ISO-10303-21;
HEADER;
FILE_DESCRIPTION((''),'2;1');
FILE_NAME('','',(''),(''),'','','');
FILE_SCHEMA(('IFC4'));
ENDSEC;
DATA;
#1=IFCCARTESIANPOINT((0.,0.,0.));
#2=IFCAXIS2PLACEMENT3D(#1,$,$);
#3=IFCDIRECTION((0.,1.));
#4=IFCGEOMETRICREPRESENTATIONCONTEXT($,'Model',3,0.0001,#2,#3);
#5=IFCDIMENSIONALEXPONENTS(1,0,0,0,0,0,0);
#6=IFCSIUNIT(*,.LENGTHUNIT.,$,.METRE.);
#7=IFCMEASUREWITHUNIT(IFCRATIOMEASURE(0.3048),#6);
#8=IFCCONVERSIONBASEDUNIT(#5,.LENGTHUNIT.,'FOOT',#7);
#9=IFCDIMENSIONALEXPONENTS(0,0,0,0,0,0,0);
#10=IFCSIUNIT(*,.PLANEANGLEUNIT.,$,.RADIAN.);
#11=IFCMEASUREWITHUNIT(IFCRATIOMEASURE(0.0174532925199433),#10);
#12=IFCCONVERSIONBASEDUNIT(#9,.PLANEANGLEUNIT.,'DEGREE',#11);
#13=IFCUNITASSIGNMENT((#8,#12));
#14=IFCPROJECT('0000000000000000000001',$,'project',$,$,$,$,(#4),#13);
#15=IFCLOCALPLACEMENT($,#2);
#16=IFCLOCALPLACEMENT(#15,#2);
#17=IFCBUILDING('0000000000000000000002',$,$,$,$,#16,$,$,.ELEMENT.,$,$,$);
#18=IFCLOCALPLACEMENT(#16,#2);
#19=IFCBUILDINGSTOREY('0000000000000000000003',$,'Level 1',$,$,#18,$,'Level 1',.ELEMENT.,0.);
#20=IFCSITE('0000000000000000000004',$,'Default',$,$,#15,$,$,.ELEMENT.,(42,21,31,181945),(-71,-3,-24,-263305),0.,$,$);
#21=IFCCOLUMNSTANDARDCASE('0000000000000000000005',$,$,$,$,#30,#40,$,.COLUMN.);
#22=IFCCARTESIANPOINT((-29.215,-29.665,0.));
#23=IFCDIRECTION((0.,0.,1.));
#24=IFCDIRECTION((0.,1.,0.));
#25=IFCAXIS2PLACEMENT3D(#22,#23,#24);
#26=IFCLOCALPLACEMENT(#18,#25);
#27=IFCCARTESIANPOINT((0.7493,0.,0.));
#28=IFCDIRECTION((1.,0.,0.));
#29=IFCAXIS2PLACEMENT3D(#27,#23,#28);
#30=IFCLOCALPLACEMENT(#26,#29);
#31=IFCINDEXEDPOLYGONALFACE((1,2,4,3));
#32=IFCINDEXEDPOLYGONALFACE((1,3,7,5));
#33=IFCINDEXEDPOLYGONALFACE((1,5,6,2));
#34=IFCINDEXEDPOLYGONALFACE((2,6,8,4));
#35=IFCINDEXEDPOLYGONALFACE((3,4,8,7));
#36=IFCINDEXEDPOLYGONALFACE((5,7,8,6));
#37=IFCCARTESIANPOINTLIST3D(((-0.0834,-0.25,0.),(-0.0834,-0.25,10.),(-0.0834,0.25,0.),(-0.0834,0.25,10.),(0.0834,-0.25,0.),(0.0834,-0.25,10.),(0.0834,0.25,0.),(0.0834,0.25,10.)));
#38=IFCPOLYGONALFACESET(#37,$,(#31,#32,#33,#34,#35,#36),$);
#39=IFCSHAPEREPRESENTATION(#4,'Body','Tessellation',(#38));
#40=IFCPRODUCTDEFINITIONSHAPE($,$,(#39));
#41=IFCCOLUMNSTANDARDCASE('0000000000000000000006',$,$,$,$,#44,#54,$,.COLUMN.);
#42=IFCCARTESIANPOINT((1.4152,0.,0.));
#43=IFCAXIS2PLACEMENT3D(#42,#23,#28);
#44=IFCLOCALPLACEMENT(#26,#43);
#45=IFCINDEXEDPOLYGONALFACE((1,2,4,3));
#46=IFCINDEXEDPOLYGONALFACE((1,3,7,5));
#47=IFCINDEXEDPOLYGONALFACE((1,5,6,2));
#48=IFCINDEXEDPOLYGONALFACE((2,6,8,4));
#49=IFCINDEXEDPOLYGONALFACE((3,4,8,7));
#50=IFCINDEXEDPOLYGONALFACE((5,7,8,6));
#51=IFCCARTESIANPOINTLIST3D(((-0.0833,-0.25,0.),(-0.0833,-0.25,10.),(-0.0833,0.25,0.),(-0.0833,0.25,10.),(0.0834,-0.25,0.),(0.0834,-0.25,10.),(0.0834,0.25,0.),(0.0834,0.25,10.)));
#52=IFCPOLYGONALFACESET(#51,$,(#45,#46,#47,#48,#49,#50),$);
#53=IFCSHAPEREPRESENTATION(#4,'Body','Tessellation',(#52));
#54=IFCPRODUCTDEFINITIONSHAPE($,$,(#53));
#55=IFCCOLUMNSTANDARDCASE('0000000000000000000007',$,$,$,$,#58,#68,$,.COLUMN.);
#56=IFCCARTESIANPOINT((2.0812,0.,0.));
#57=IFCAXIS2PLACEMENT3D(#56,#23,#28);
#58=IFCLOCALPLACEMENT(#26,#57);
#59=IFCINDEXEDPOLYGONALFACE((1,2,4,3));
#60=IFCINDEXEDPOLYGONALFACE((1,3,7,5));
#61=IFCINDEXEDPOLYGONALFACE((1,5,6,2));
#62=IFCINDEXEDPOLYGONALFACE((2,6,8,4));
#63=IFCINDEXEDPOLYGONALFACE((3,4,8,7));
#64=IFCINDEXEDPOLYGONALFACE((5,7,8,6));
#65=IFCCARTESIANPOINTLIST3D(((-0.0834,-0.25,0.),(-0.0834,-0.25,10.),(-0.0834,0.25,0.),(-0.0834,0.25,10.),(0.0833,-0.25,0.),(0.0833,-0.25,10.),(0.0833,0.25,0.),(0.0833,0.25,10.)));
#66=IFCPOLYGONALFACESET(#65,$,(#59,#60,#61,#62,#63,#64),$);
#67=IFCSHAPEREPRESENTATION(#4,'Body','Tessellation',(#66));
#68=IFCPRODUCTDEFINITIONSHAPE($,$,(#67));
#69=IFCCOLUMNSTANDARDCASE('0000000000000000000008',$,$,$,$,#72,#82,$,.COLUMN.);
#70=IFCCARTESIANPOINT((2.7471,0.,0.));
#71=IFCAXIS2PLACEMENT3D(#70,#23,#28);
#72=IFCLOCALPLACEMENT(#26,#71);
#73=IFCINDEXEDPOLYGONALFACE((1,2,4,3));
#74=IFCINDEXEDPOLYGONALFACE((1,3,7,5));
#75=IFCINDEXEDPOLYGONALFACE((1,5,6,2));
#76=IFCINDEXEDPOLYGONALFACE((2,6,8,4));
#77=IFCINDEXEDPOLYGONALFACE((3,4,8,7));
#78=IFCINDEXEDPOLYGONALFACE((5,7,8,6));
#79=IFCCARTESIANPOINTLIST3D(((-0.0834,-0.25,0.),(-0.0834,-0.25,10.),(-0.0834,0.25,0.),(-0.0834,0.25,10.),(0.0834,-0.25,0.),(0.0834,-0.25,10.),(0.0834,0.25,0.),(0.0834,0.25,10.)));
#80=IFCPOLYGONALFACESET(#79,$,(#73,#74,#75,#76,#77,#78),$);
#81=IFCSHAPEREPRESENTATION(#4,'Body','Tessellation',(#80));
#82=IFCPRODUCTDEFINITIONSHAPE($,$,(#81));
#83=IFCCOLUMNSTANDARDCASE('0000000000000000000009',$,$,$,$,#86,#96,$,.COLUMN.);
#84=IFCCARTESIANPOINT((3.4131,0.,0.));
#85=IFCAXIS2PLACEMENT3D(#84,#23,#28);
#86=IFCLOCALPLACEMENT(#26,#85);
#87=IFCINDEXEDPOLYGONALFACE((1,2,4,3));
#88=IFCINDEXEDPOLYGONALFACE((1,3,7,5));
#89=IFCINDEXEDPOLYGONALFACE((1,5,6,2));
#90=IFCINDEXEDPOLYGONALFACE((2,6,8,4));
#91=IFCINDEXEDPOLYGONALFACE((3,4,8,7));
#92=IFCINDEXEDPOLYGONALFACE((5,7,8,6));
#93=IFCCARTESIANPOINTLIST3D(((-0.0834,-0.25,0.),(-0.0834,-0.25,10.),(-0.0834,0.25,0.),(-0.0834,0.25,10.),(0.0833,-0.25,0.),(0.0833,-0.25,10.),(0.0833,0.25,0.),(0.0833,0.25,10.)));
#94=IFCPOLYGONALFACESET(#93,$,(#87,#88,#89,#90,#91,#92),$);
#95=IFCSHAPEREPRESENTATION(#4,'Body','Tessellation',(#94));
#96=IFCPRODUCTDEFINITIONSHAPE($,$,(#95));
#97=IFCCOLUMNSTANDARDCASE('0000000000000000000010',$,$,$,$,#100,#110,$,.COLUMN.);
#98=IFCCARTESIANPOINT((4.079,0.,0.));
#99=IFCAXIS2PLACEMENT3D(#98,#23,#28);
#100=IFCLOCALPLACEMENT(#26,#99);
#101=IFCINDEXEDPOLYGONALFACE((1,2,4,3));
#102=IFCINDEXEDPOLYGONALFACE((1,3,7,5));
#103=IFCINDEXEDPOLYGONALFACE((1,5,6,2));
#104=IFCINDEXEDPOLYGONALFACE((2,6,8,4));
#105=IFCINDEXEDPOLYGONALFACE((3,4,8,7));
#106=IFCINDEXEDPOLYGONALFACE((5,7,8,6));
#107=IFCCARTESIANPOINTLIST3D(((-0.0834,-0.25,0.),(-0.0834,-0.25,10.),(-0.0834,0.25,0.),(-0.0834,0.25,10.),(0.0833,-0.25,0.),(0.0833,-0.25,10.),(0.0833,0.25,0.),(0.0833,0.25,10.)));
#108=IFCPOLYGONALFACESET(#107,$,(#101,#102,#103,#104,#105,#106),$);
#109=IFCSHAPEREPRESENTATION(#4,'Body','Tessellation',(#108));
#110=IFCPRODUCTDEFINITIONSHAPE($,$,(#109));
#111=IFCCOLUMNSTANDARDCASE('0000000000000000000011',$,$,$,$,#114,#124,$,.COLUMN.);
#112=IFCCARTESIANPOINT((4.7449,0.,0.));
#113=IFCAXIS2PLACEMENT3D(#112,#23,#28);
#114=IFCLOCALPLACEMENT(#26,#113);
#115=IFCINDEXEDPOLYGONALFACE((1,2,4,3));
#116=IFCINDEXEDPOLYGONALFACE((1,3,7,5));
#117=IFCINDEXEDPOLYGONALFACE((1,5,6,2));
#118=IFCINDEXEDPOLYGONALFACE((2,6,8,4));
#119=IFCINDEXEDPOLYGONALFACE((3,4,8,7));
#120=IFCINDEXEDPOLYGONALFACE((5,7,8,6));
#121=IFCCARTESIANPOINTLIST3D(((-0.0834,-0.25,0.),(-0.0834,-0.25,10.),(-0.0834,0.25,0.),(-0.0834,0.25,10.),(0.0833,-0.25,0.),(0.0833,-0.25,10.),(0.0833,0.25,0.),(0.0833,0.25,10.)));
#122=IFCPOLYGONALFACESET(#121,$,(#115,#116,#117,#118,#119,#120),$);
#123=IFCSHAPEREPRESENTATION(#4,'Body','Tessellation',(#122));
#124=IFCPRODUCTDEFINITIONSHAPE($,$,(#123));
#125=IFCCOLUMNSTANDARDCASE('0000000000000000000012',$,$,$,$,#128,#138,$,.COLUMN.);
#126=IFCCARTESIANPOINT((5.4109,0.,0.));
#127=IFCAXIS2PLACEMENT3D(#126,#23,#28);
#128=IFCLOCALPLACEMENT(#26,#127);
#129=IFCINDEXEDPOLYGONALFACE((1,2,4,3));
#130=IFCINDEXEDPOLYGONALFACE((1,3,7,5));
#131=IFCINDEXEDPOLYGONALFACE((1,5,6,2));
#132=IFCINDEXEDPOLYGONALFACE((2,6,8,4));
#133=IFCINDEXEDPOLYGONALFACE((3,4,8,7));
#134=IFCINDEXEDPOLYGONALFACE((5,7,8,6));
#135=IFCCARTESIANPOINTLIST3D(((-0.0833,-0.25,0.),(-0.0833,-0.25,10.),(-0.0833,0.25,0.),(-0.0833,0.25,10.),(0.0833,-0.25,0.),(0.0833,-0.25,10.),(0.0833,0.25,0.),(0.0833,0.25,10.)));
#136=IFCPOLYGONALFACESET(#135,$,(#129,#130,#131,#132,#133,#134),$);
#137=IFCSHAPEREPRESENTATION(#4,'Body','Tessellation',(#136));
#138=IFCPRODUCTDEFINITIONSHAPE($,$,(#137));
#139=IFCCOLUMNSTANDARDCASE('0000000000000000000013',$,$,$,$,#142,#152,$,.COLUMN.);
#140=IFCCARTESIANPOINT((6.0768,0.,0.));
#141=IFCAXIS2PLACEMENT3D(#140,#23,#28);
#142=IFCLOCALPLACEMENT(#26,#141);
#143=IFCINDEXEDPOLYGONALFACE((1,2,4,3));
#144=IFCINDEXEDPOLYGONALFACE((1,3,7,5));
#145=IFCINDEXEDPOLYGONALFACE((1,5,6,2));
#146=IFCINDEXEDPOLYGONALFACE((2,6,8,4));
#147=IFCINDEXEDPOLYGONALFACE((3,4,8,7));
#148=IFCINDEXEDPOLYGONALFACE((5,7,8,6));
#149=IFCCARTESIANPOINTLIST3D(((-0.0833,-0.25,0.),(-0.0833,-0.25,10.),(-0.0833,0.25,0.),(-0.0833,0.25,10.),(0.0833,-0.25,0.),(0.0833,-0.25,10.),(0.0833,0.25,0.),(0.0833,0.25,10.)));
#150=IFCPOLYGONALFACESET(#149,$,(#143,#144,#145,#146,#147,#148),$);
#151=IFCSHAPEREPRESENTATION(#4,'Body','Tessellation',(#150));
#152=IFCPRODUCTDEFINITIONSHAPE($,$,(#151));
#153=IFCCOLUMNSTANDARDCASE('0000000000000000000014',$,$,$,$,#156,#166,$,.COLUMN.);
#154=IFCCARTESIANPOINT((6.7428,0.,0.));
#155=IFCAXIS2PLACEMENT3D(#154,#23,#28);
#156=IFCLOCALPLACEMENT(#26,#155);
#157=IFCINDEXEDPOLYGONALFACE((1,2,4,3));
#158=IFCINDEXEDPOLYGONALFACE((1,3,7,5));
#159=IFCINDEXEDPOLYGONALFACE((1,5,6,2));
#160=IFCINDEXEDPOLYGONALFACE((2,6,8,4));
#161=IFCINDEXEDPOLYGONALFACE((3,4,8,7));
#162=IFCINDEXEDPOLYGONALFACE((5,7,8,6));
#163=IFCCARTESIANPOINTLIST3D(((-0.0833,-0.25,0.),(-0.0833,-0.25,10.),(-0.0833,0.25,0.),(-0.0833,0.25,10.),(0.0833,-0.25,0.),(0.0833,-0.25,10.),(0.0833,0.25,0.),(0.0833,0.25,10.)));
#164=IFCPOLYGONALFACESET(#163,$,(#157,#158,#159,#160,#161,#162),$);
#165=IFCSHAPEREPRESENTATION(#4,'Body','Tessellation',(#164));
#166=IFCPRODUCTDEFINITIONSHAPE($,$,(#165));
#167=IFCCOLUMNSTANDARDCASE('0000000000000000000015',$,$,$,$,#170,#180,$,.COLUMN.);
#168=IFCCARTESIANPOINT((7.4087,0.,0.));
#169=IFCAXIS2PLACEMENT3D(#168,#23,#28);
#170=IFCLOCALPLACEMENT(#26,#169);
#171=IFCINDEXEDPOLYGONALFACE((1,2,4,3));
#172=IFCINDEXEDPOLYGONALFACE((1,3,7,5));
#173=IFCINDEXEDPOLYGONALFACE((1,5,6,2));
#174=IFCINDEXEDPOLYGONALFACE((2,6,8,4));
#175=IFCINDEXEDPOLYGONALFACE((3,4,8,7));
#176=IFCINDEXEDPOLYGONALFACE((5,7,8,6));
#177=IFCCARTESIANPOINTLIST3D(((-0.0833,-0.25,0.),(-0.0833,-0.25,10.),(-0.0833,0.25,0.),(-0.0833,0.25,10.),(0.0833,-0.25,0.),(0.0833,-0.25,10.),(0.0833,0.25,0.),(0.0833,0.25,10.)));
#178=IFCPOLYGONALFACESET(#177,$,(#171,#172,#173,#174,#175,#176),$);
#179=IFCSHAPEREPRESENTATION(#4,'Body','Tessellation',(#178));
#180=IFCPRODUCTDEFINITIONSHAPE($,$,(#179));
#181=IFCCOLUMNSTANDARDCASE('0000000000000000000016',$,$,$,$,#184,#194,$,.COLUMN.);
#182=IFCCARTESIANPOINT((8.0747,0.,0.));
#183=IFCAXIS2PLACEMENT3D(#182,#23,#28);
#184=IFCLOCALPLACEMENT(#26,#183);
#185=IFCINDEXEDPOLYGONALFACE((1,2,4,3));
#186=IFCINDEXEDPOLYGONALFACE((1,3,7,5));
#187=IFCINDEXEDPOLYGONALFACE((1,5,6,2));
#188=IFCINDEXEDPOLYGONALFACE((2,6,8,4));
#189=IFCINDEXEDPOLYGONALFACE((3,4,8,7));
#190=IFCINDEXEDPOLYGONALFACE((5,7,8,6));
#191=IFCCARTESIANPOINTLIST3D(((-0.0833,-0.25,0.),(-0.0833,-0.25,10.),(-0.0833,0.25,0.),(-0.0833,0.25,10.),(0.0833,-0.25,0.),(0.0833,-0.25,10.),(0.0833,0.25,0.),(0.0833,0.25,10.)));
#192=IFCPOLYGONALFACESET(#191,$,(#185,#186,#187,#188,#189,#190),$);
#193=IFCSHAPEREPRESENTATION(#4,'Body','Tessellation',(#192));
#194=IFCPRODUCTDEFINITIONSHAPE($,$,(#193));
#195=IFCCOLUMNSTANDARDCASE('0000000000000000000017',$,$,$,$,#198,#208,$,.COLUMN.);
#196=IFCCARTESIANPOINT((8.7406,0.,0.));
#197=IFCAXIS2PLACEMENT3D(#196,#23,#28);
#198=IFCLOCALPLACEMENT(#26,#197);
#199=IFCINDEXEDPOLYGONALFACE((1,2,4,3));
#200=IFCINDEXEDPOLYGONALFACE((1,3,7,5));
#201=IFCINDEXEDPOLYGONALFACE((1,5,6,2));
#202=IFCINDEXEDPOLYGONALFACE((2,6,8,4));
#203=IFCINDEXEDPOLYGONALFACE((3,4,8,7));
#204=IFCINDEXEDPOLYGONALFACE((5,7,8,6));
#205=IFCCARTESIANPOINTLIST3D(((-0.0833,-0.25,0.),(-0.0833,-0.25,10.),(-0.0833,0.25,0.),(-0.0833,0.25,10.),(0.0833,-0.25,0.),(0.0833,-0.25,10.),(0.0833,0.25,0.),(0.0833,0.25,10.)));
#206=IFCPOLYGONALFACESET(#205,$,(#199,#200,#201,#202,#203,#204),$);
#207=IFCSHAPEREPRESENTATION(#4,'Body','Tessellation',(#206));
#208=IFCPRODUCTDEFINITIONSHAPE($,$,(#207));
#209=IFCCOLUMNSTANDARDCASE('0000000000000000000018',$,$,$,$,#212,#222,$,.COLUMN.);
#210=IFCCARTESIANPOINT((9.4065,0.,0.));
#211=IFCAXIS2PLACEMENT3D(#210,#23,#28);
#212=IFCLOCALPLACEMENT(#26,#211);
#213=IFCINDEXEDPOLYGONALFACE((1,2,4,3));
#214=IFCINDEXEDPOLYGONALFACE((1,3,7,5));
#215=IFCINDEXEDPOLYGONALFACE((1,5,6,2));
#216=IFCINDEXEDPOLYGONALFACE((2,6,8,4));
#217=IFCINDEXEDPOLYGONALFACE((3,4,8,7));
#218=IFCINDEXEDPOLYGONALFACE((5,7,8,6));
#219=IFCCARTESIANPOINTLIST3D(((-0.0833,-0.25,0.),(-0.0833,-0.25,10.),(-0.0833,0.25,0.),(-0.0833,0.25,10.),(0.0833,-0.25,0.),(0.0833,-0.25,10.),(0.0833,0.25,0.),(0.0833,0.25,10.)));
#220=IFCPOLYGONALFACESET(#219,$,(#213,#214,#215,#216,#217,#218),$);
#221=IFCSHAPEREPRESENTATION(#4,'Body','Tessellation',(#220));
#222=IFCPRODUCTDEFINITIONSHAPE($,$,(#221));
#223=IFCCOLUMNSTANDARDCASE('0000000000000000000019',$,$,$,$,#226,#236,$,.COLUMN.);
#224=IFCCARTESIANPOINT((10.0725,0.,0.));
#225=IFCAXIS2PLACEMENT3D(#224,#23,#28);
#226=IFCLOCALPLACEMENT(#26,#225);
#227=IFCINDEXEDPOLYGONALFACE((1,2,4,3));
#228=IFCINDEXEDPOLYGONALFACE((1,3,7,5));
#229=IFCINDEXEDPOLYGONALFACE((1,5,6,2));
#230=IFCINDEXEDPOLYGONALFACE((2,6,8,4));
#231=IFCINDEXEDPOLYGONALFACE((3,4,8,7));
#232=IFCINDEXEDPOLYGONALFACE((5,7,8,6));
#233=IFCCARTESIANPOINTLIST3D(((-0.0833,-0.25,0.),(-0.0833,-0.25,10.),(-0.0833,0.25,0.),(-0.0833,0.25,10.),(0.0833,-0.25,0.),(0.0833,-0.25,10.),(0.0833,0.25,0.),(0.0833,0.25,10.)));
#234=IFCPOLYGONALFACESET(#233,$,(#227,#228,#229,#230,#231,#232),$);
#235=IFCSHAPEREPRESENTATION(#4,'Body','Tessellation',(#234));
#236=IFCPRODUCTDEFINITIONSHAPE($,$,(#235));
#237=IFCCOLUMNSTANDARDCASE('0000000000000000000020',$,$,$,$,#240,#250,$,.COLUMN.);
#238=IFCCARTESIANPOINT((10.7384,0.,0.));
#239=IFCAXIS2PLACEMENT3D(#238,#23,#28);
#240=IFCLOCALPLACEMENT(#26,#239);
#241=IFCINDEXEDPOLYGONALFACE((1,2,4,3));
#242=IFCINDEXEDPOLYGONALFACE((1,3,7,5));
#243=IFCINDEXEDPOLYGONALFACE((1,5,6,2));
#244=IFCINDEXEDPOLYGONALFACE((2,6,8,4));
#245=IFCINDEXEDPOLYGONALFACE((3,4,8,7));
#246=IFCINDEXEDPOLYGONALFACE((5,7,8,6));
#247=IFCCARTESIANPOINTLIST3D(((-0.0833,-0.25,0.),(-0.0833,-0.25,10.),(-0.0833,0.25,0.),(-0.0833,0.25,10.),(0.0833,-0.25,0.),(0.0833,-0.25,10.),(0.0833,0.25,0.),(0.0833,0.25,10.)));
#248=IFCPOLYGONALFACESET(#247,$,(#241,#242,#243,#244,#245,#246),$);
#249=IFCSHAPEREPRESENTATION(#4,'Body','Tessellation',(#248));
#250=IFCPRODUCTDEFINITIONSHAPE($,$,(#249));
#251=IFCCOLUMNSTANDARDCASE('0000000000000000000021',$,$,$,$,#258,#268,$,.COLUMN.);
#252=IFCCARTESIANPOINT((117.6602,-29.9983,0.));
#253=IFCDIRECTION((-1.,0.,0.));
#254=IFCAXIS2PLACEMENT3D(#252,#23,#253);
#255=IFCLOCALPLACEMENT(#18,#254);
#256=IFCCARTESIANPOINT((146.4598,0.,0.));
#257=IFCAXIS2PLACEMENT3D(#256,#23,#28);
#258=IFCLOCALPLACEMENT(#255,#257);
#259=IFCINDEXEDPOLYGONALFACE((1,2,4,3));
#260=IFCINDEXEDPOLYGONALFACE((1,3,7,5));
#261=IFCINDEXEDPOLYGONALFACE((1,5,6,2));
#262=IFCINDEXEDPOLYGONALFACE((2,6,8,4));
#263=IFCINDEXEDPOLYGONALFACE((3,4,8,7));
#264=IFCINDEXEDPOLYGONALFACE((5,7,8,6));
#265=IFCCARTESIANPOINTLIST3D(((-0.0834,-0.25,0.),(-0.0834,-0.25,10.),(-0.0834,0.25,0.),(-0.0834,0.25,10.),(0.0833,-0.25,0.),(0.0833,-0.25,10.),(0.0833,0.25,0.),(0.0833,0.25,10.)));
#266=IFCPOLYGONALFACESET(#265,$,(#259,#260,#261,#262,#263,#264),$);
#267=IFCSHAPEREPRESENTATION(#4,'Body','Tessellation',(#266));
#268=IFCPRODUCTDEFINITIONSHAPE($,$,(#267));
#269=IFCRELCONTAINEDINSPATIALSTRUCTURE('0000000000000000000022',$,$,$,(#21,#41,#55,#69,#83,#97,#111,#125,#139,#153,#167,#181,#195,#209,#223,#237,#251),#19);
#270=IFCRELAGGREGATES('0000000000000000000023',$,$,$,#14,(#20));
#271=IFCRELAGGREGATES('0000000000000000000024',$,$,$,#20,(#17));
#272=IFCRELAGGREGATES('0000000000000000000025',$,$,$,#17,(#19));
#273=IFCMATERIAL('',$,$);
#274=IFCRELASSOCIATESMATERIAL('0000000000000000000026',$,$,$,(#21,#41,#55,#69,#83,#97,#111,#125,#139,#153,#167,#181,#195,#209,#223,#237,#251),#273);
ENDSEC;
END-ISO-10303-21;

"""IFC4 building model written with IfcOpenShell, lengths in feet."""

from ifc_helpers import new_model, entity, si_unit, converted_unit, direction, frame, origin, place, context, project, spatial, rectangle, extrude, material, element, save


model = new_model("IFC4")

# Units and contexts
model_context = context("Model", 3, precision=0.0001, world=origin(), true_north=direction((0.0, 1.0)))
ifc_project = project(units=[converted_unit("LENGTHUNIT", "FOOT", entity("IfcRatioMeasure", 0.3048), si_unit("LENGTHUNIT", "METRE"), dimensions=[1, 0, 0, 0, 0, 0, 0]), converted_unit("PLANEANGLEUNIT", "DEGREE", entity("IfcRatioMeasure", 0.0174532925199433), si_unit("PLANEANGLEUNIT", "RADIAN"), dimensions=[0, 0, 0, 0, 0, 0, 0])], contexts=[model_context])

# Site, building, storey
site_placement = place(None, origin())
site = spatial("IfcSite", under=ifc_project, at=site_placement, Name="Default", CompositionType="ELEMENT", RefLatitude=(42, 21, 31, 181945), RefLongitude=(-71, -3, -24, -263305), RefElevation=0.0)
building_placement = place(site_placement, origin())
building = spatial("IfcBuilding", under=site, at=building_placement, CompositionType="ELEMENT")
storey_placement = place(building_placement, origin())
storey = spatial("IfcBuildingStorey", under=building, at=storey_placement, Name="Level 1", LongName="Level 1", CompositionType="ELEMENT", Elevation=0.0)

# Columns
ifc_material_1 = material(Name="")
wall_placement = place(storey_placement, frame((-29.215, -29.665, 0.0), z_axis=(0.0, 0.0, 1.0), x_axis=(0.0, 1.0, 0.0)))
for number, where, z_axis, x_axis in (
    (1, (0.7493, 0.0, 0.0), (0.0, 0.0, 1.0), (1.0, 0.0, 0.0)),
    (2, (1.4152, 0.0, 0.0), (0.0, 0.0, 1.0), (1.0, 0.0, 0.0)),
    (3, (2.0812, 0.0, 0.0), (0.0, 0.0, 1.0), (1.0, 0.0, 0.0)),
    (4, (2.7471, 0.0, 0.0), (0.0, 0.0, 1.0), (1.0, 0.0, 0.0)),
    (5, (3.4131, 0.0, 0.0), (0.0, 0.0, 1.0), (1.0, 0.0, 0.0)),
    (6, (4.079, 0.0, 0.0), (0.0, 0.0, 1.0), (1.0, 0.0, 0.0)),
    (7, (4.7449, 0.0, 0.0), (0.0, 0.0, 1.0), (1.0, 0.0, 0.0)),
    (8, (5.4109, 0.0, 0.0), (0.0, 0.0, 1.0), (1.0, 0.0, 0.0)),
    (9, (6.0768, 0.0, 0.0), (0.0, 0.0, 1.0), (1.0, 0.0, 0.0)),
    (10, (6.7428, 0.0, 0.0), (0.0, 0.0, 1.0), (1.0, 0.0, 0.0)),
    (11, (7.4087, 0.0, 0.0), (0.0, 0.0, 1.0), (1.0, 0.0, 0.0)),
    (12, (8.0747, 0.0, 0.0), (0.0, 0.0, 1.0), (1.0, 0.0, 0.0)),
    (13, (8.7406, 0.0, 0.0), (0.0, 0.0, 1.0), (1.0, 0.0, 0.0)),
    (14, (9.4065, 0.0, 0.0), (0.0, 0.0, 1.0), (1.0, 0.0, 0.0)),
    (15, (10.0725, 0.0, 0.0), (0.0, 0.0, 1.0), (1.0, 0.0, 0.0)),
    (16, (10.7384, 0.0, 0.0), (0.0, 0.0, 1.0), (1.0, 0.0, 0.0)),
):
    element("IfcColumnStandardCase", number, at=place(wall_placement, frame(where, z_axis=z_axis, x_axis=x_axis)), inside=storey, material=ifc_material_1, PredefinedType="COLUMN", context=model_context, shape_type="SweptSolid", body=[
        extrude(rectangle(XDim=0.1667, YDim=0.5), origin(), (0.0, 0.0, 1.0), 10.0),
    ])
placement = place(storey_placement, frame((117.6602, -29.9983, 0.0), z_axis=(0.0, 0.0, 1.0), x_axis=(-1.0, 0.0, 0.0)))
for number, where, z_axis, x_axis in (
    (17, (146.4598, 0.0, 0.0), (0.0, 0.0, 1.0), (1.0, 0.0, 0.0)),
):
    element("IfcColumnStandardCase", number, at=place(placement, frame(where, z_axis=z_axis, x_axis=x_axis)), inside=storey, material=ifc_material_1, PredefinedType="COLUMN", context=model_context, shape_type="SweptSolid", body=[
        extrude(rectangle(XDim=0.1667, YDim=0.5), origin(), (0.0, 0.0, 1.0), 10.0),
    ])

save(model, "model.ifc")
